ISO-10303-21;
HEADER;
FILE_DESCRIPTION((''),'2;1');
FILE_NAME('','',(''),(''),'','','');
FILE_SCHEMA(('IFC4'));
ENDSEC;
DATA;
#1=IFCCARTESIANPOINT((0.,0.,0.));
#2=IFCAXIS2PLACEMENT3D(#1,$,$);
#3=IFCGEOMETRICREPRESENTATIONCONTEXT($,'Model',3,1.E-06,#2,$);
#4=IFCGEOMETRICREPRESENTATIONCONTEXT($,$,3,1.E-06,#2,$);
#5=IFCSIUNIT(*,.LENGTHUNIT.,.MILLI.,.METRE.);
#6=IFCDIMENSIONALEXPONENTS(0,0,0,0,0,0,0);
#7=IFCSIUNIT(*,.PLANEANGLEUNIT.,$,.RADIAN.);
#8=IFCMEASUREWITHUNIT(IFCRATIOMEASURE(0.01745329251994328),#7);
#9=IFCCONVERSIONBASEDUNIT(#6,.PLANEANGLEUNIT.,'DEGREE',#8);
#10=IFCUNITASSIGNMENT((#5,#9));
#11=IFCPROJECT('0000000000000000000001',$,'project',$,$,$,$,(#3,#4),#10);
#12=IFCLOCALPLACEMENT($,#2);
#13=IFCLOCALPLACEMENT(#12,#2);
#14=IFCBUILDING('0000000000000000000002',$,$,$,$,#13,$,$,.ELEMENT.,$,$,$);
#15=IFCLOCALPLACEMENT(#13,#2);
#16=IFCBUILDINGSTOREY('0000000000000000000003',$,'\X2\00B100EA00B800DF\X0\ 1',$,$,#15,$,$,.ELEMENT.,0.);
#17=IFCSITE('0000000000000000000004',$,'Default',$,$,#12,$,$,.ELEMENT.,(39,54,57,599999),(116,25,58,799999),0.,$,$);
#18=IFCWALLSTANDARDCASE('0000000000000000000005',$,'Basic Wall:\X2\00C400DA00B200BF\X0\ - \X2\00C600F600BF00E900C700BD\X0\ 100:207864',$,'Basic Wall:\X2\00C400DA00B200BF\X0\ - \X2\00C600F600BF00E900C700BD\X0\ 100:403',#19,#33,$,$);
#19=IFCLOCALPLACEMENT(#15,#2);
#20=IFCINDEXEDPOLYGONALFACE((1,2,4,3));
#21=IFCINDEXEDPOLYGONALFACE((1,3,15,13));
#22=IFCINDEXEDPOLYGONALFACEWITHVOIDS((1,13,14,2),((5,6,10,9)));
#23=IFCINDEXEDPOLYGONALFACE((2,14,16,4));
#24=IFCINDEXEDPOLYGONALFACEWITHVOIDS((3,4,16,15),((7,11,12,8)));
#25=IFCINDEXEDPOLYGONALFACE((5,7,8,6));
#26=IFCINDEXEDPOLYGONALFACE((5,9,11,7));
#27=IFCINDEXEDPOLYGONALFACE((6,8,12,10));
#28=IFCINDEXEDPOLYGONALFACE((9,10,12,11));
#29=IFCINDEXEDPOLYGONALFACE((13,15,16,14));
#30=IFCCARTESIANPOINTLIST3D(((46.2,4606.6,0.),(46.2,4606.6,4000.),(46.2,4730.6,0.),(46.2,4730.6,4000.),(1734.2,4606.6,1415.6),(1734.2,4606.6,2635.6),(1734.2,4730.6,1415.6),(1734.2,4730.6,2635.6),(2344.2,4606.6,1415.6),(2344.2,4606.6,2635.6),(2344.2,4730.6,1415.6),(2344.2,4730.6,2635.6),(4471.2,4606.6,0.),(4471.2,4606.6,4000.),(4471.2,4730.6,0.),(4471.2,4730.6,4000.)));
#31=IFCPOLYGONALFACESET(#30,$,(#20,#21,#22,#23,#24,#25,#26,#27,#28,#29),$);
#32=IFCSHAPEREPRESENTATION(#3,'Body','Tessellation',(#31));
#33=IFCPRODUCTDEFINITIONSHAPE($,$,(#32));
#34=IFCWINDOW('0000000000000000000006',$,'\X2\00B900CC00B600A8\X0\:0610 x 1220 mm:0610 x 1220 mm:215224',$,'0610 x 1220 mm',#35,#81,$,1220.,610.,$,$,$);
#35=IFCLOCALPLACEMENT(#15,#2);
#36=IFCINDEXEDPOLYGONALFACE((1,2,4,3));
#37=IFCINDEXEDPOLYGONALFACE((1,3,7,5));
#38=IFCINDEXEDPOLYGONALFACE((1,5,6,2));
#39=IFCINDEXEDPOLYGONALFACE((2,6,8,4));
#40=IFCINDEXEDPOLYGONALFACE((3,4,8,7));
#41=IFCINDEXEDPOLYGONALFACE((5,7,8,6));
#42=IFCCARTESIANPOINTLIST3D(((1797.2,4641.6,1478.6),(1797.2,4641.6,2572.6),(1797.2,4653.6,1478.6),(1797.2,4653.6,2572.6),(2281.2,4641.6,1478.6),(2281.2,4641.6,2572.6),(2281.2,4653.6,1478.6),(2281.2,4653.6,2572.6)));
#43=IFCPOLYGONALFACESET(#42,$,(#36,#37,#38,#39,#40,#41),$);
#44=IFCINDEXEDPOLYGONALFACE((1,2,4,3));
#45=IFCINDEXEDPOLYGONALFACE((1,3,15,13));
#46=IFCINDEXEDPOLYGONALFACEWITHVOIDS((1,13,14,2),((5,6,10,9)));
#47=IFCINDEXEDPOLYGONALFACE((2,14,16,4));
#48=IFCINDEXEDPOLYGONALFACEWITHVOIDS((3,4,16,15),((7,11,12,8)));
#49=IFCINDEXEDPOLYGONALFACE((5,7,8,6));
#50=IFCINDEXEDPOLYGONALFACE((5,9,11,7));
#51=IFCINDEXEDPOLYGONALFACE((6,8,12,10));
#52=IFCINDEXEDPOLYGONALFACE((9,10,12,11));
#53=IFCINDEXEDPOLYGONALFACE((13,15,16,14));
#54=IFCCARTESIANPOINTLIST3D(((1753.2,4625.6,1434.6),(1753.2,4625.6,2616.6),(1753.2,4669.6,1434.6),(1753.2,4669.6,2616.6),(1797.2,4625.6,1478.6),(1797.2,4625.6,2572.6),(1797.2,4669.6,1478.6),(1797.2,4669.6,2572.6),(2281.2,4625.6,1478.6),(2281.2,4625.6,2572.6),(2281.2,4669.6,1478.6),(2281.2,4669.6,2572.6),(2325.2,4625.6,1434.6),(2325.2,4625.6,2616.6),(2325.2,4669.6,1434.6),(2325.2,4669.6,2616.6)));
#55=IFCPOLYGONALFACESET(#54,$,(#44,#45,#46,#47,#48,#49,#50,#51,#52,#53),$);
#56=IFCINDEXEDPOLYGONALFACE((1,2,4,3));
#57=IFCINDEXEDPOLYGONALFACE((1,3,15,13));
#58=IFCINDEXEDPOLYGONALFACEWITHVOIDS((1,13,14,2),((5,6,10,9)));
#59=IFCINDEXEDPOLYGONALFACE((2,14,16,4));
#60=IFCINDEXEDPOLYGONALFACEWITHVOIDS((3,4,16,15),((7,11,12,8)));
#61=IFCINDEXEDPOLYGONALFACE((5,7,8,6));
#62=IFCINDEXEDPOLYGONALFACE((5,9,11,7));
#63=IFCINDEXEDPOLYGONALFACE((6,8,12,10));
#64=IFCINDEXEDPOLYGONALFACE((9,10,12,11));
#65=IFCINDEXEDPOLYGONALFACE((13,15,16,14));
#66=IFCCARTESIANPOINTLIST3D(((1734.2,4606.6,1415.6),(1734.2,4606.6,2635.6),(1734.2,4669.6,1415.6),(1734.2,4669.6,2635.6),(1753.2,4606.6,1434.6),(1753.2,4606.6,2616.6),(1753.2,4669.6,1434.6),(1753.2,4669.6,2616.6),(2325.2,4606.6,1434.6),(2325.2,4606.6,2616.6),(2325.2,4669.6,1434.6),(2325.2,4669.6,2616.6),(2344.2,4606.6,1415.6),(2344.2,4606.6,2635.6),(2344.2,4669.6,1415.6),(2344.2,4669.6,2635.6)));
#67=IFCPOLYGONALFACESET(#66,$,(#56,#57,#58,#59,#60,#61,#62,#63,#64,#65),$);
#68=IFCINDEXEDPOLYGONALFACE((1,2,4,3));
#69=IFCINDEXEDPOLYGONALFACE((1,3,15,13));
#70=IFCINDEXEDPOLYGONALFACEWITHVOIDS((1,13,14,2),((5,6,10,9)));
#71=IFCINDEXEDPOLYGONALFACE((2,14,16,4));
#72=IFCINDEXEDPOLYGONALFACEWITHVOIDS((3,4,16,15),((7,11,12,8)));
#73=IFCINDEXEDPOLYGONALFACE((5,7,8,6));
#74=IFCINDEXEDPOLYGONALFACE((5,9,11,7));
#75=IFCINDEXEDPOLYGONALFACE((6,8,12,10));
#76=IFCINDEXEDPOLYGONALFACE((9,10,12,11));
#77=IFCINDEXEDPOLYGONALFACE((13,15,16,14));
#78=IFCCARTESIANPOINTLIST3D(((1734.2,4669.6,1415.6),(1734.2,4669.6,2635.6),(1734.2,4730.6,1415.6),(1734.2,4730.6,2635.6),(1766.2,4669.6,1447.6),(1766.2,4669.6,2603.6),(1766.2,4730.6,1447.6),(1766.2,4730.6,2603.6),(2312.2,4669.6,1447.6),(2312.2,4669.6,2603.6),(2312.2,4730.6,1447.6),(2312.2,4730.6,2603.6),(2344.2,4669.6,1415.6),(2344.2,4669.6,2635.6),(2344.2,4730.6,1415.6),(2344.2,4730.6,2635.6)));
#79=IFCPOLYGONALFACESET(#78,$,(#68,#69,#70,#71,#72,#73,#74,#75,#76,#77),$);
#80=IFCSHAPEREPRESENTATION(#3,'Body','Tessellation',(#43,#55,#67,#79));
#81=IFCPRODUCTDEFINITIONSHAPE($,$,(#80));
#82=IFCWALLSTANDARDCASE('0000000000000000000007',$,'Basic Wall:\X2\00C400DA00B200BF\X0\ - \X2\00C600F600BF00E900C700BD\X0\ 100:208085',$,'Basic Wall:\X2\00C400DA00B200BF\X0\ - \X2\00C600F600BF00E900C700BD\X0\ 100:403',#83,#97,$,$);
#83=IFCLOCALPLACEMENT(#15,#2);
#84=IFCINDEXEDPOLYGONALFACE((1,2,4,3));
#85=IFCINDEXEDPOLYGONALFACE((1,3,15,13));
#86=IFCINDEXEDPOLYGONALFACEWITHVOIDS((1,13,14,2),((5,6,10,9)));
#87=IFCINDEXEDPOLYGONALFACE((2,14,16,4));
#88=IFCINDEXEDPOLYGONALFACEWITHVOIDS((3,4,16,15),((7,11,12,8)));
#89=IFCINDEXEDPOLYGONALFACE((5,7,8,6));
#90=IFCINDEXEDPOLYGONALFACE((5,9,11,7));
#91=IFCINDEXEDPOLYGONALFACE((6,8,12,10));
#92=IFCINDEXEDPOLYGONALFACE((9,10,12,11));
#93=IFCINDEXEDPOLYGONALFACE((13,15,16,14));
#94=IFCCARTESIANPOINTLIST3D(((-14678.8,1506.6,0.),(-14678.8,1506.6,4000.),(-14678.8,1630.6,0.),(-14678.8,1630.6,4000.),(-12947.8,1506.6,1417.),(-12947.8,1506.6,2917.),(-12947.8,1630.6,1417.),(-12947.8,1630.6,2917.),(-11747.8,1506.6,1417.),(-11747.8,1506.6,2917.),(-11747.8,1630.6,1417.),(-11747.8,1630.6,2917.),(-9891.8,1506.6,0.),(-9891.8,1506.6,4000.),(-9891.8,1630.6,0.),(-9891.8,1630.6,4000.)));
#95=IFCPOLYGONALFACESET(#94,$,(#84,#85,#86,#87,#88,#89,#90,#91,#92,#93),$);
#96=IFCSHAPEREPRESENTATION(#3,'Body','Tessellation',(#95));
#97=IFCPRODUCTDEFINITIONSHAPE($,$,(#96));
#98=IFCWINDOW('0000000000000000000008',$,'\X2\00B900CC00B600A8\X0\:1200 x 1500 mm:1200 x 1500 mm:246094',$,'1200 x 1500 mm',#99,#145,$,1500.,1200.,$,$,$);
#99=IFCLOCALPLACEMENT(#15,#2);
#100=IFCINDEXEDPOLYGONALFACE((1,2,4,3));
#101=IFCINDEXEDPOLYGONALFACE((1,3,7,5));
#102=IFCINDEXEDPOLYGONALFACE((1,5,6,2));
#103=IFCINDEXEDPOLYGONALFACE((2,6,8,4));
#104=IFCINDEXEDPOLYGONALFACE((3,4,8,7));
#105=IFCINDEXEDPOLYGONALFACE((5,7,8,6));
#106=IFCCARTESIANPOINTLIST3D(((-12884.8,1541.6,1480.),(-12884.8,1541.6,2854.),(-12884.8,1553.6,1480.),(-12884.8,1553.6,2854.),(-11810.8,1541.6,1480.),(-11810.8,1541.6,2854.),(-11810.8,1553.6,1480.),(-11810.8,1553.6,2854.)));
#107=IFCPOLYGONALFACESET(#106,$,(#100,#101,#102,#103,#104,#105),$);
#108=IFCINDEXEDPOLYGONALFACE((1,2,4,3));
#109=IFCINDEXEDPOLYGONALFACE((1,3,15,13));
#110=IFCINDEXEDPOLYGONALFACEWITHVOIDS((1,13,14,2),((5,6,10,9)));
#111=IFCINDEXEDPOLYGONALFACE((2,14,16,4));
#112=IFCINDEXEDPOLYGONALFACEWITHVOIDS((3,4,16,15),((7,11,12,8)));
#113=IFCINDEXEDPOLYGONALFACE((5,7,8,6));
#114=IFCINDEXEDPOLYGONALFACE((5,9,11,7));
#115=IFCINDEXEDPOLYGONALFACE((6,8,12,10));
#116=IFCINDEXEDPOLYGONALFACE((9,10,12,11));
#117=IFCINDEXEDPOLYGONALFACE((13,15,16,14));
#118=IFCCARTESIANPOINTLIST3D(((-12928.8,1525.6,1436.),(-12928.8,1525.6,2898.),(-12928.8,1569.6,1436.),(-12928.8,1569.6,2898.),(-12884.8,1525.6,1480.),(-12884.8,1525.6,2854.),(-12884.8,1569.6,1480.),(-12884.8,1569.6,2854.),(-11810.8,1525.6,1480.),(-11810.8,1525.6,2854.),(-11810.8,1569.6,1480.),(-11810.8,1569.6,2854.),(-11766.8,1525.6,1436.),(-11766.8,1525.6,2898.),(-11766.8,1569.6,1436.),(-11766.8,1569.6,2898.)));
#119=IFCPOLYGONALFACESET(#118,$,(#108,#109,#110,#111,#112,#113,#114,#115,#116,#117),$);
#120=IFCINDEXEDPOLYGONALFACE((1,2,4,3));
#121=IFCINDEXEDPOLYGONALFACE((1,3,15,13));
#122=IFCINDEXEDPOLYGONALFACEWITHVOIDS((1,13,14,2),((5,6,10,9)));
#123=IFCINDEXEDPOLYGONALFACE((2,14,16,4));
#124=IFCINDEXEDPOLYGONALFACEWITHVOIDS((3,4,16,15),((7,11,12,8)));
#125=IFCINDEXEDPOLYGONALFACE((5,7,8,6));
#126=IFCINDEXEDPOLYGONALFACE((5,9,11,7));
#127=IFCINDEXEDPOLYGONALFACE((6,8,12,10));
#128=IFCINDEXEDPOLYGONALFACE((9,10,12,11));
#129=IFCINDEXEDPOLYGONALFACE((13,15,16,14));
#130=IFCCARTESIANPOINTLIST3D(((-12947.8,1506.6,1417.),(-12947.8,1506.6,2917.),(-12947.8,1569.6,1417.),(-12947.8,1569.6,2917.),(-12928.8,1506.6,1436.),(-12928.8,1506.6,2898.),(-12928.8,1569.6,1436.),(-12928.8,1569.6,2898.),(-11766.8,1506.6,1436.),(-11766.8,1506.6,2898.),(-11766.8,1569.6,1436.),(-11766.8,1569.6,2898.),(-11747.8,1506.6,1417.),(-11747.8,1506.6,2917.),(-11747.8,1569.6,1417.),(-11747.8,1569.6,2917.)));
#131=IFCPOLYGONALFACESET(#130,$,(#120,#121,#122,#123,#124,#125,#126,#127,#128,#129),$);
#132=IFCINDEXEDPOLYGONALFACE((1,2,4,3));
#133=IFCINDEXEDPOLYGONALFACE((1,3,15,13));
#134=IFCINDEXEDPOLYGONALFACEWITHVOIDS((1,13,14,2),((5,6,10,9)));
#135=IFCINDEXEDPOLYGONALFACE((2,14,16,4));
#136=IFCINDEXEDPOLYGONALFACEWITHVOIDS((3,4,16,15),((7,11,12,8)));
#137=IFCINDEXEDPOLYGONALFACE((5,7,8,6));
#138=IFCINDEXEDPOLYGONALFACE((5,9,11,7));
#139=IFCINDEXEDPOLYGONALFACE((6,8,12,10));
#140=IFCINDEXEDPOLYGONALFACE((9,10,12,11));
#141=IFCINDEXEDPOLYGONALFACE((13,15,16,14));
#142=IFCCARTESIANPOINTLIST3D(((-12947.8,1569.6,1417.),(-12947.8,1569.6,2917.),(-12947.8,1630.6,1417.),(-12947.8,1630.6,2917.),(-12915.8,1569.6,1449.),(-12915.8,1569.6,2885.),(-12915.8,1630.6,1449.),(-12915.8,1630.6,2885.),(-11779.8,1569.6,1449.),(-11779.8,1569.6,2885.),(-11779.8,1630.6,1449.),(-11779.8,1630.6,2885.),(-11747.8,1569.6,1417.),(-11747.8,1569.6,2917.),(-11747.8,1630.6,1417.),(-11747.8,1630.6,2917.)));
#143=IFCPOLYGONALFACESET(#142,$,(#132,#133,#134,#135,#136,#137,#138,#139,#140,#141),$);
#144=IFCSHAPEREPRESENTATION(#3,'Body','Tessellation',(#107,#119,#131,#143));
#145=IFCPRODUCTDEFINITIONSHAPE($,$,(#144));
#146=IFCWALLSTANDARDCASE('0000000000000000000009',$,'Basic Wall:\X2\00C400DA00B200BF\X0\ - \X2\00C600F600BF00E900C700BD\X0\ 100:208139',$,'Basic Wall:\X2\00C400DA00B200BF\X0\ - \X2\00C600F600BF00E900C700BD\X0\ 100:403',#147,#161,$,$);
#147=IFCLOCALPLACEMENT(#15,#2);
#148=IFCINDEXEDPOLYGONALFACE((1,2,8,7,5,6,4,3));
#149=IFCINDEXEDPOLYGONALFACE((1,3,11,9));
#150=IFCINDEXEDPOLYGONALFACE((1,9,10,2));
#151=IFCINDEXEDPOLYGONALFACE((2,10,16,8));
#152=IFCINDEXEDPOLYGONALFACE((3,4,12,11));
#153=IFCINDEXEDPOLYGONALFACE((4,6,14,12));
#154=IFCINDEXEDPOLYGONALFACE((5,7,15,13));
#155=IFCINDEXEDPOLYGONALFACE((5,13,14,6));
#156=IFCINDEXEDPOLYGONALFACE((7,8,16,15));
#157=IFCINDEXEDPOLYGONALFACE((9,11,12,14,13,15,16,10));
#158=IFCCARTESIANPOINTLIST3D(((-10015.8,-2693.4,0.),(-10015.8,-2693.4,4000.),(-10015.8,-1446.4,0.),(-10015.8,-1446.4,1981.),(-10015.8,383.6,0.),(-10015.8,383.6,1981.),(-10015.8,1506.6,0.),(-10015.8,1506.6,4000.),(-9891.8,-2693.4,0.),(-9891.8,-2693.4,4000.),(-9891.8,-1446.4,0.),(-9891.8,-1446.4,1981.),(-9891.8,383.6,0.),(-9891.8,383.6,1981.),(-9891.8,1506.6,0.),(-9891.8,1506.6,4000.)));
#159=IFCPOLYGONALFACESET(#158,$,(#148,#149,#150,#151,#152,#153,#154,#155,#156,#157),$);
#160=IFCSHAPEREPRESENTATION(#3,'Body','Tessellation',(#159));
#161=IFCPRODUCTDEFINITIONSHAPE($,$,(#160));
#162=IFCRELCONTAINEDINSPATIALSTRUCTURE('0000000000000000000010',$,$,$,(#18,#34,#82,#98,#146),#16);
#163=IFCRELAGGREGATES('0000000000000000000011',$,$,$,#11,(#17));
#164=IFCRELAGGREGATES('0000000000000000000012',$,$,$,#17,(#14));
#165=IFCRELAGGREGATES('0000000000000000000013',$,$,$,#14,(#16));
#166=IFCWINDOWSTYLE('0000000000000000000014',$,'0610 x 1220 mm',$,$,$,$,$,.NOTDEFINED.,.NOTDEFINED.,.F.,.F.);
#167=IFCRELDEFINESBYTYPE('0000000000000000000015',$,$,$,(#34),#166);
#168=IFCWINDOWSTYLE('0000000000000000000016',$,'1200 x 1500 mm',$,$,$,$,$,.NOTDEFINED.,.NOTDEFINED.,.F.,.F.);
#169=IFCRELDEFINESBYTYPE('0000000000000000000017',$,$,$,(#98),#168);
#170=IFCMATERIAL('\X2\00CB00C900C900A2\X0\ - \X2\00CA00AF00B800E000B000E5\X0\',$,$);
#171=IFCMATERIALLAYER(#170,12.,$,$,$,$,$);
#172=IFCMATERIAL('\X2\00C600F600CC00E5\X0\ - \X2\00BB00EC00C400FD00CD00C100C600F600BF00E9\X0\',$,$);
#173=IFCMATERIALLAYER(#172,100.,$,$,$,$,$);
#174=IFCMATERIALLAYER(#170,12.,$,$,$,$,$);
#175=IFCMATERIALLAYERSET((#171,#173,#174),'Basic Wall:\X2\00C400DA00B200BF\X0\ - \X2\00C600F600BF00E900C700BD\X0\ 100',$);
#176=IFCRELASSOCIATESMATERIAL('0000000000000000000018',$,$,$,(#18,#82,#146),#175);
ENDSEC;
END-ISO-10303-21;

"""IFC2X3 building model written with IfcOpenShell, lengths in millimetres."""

from ifc_helpers import new_model, entity, si_unit, converted_unit, frame, frame_2d, origin, origin_2d_with_axis, place, context, project, spatial, polyline, rectangle, outline, extrude, source, transform, mapped, material, layer, layer_set, layer_usage, type_object, type_shapes, element, fill, save


model = new_model("IFC2X3")

# Units and contexts
model_context = context("Model", 3, precision=1e-06, world=origin())
context_of_model = context(None, 3, precision=1e-06, world=origin())
ifc_project = project(units=[si_unit("LENGTHUNIT", "METRE", prefix="MILLI"), converted_unit("PLANEANGLEUNIT", "DEGREE", entity("IfcRatioMeasure", 0.01745329251994328), si_unit("PLANEANGLEUNIT", "RADIAN"), dimensions=[0, 0, 0, 0, 0, 0, 0])], contexts=[model_context, context_of_model])

# Site, building, storey
site_placement = place(None, origin())
site = spatial("IfcSite", under=ifc_project, at=site_placement, Name="Default", CompositionType="ELEMENT", RefLatitude=(39, 54, 57, 599999), RefLongitude=(116, 25, 58, 799999), RefElevation=0.0)
building_placement = place(site_placement, origin())
building = spatial("IfcBuilding", under=site, at=building_placement, CompositionType="ELEMENT")
storey_placement = place(building_placement, origin())
storey = spatial("IfcBuildingStorey", under=building, at=storey_placement, Name="±ê¸ß 1", CompositionType="ELEMENT", Elevation=0.0)

# Shared definitions
ifc_material_1 = material(Name="ËÉÉ¢ - Ê¯¸à°å")

# Shared definitions
ifc_layer_1 = layer(ifc_material_1, 12.0)
ifc_material_2 = material(Name="ÆöÌå - »ìÄýÍÁÆö¿é")
ifc_layer_2 = layer(ifc_material_2, 100.0)
ifc_layer_3 = layer(ifc_material_1, 12.0)
ifc_layer_set_1 = layer_set([ifc_layer_1, ifc_layer_2, ifc_layer_3], Name="Basic Wall:ÄÚ²¿ - Æö¿éÇ½ 100")

# Walls, openings, windows
ifc_layer_usage_1 = layer_usage(ifc_layer_set_1, "AXIS2", "NEGATIVE", 62.0)
wall_1_placement = place(storey_placement, frame((46.2, 4668.6, 0.0)))
wall_1 = element("IfcWallStandardCase", 1, at=wall_1_placement, inside=storey, material=ifc_layer_usage_1, Name="Basic Wall:ÄÚ²¿ - Æö¿éÇ½ 100:207864", ObjectType="Basic Wall:ÄÚ²¿ - Æö¿éÇ½ 100:403", context=model_context, shape_type="SweptSolid", body=[
    extrude(rectangle(XDim=4425.0, YDim=124.0, at=frame_2d((2212.5, 0.0), x_axis=(-1.0, 0.0))), origin(), (0.0, 0.0, 1.0), 4000.0),
])
opening_1_placement = place(wall_1_placement, frame((1688.0, -62.0, 1415.6)))
opening_1 = element("IfcOpeningElement", 2, at=opening_1_placement, cuts=wall_1, ObjectType="Opening", context=model_context, shape_type="SweptSolid", body=[
    extrude(rectangle(XDim=1220.0, YDim=610.0, at=frame_2d((610.0, 305.0), x_axis=(1.0, 0.0))), frame((0.0, 0.0, 0.0), z_axis=(0.0, 1.0, 0.0), x_axis=(0.0, 0.0, 1.0)), (0.0, 0.0, 1.0), 124.0),
])
window_style_1 = type_object("IfcWindowStyle", Name="0610 x 1220 mm", ConstructionType="NOTDEFINED", OperationType="NOTDEFINED", ParameterTakesPrecedence=False, Sizeable=False)
shared_shape_1 = source(origin(), model_context, "Body", "SweptSolid", [
    extrude(rectangle(XDim=12.0, YDim=484.0, at=origin_2d_with_axis()), frame((305.0, 83.0, 63.0), z_axis=(0.0, 0.0, 1.0), x_axis=(0.0, -1.0, 0.0)), (0.0, 0.0, 1.0), 1094.0),
    extrude(outline(polyline([(-286.0, -591.0), (286.0, -591.0), (286.0, 591.0), (-286.0, 591.0), (-286.0, -591.0)]), holes=[polyline([(-242.0, -547.0), (-242.0, 547.0), (242.0, 547.0), (242.0, -547.0), (-242.0, -547.0)])]), frame((305.0, 61.0, 610.0), z_axis=(0.0, 1.0, 0.0), x_axis=(1.0, 0.0, 0.0)), (0.0, 0.0, 1.0), 44.0),
    extrude(outline(polyline([(-305.0, -610.0), (305.0, -610.0), (305.0, 610.0), (-305.0, 610.0), (-305.0, -610.0)]), holes=[polyline([(-286.0, -591.0), (-286.0, 591.0), (286.0, 591.0), (286.0, -591.0), (-286.0, -591.0)])]), frame((305.0, 61.0, 610.0), z_axis=(0.0, 1.0, 0.0), x_axis=(1.0, 0.0, 0.0)), (0.0, 0.0, 1.0), 63.0),
    extrude(outline(polyline([(-305.0, -610.0), (305.0, -610.0), (305.0, 610.0), (-305.0, 610.0), (-305.0, -610.0)]), holes=[polyline([(-273.0, -578.0), (-273.0, 578.0), (273.0, 578.0), (273.0, -578.0), (-273.0, -578.0)])]), frame((305.0, 0.0, 610.0), z_axis=(0.0, 1.0, 0.0), x_axis=(1.0, 0.0, 0.0)), (0.0, 0.0, 1.0), 61.0),
])
type_shapes(window_style_1, [shared_shape_1])
window_1_placement = place(opening_1_placement, frame((610.0, 124.0, 0.0), z_axis=(0.0, 0.0, 1.0), x_axis=(-1.0, 0.0, 0.0)))
window_1 = element("IfcWindow", 3, at=window_1_placement, inside=storey, type_object=window_style_1, Name="¹Ì¶¨:0610 x 1220 mm:0610 x 1220 mm:215224", ObjectType="0610 x 1220 mm", OverallHeight=1220.0, OverallWidth=610.0, context=model_context, shape_type="MappedRepresentation", body=[
    mapped(shared_shape_1, transform((0.0, 0.0, 0.0), scale=1.0)),
])
fill(opening_1, window_1)
ifc_layer_usage_2 = layer_usage(ifc_layer_set_1, "AXIS2", "NEGATIVE", 62.0)
wall_2_placement = place(storey_placement, frame((-14678.8, 1568.6, 0.0)))
wall_2 = element("IfcWallStandardCase", 4, at=wall_2_placement, inside=storey, material=ifc_layer_usage_2, Name="Basic Wall:ÄÚ²¿ - Æö¿éÇ½ 100:208085", ObjectType="Basic Wall:ÄÚ²¿ - Æö¿éÇ½ 100:403", context=model_context, shape_type="SweptSolid", body=[
    extrude(rectangle(XDim=4787.0, YDim=124.0, at=frame_2d((2393.5, 0.0), x_axis=(-1.0, 0.0))), origin(), (0.0, 0.0, 1.0), 4000.0),
])
opening_2_placement = place(wall_2_placement, frame((1731.0, -62.0, 1417.0)))
opening_2 = element("IfcOpeningElement", 5, at=opening_2_placement, cuts=wall_2, ObjectType="Opening", context=model_context, shape_type="SweptSolid", body=[
    extrude(rectangle(XDim=1500.0, YDim=1200.0, at=frame_2d((750.0, 600.0), x_axis=(1.0, 0.0))), frame((0.0, 0.0, 0.0), z_axis=(0.0, 1.0, 0.0), x_axis=(0.0, 0.0, 1.0)), (0.0, 0.0, 1.0), 124.0),
])
window_style_2 = type_object("IfcWindowStyle", Name="1200 x 1500 mm", ConstructionType="NOTDEFINED", OperationType="NOTDEFINED", ParameterTakesPrecedence=False, Sizeable=False)
shared_shape_2 = source(origin(), model_context, "Body", "SweptSolid", [
    extrude(rectangle(XDim=12.0, YDim=1074.0, at=origin_2d_with_axis()), frame((600.0, 83.0, 63.0), z_axis=(0.0, 0.0, 1.0), x_axis=(0.0, -1.0, 0.0)), (0.0, 0.0, 1.0), 1374.0),
    extrude(outline(polyline([(-581.0, -731.0), (581.0, -731.0), (581.0, 731.0), (-581.0, 731.0), (-581.0, -731.0)]), holes=[polyline([(-537.0, -687.0), (-537.0, 687.0), (537.0, 687.0), (537.0, -687.0), (-537.0, -687.0)])]), frame((600.0, 61.0, 750.0), z_axis=(0.0, 1.0, 0.0), x_axis=(1.0, 0.0, 0.0)), (0.0, 0.0, 1.0), 44.0),
    extrude(outline(polyline([(-600.0, -750.0), (600.0, -750.0), (600.0, 750.0), (-600.0, 750.0), (-600.0, -750.0)]), holes=[polyline([(-581.0, -731.0), (-581.0, 731.0), (581.0, 731.0), (581.0, -731.0), (-581.0, -731.0)])]), frame((600.0, 61.0, 750.0), z_axis=(0.0, 1.0, 0.0), x_axis=(1.0, 0.0, 0.0)), (0.0, 0.0, 1.0), 63.0),
    extrude(outline(polyline([(-600.0, -750.0), (600.0, -750.0), (600.0, 750.0), (-600.0, 750.0), (-600.0, -750.0)]), holes=[polyline([(-568.0, -718.0), (-568.0, 718.0), (568.0, 718.0), (568.0, -718.0), (-568.0, -718.0)])]), frame((600.0, 0.0, 750.0), z_axis=(0.0, 1.0, 0.0), x_axis=(1.0, 0.0, 0.0)), (0.0, 0.0, 1.0), 61.0),
])
type_shapes(window_style_2, [shared_shape_2])
window_2_placement = place(opening_2_placement, frame((1200.0, 124.0, 0.0), z_axis=(0.0, 0.0, 1.0), x_axis=(-1.0, 0.0, 0.0)))
window_2 = element("IfcWindow", 6, at=window_2_placement, inside=storey, type_object=window_style_2, Name="¹Ì¶¨:1200 x 1500 mm:1200 x 1500 mm:246094", ObjectType="1200 x 1500 mm", OverallHeight=1500.0, OverallWidth=1200.0, context=model_context, shape_type="MappedRepresentation", body=[
    mapped(shared_shape_2, transform((0.0, 0.0, 0.0), scale=1.0)),
])
fill(opening_2, window_2)

# Wall, opening
ifc_layer_usage_3 = layer_usage(ifc_layer_set_1, "AXIS2", "NEGATIVE", 62.0)
wall_3_placement = place(storey_placement, frame((-9953.8, 1506.6, 0.0), z_axis=(0.0, 0.0, 1.0), x_axis=(0.0, -1.0, 0.0)))
wall_3 = element("IfcWallStandardCase", 7, at=wall_3_placement, inside=storey, material=ifc_layer_usage_3, Name="Basic Wall:ÄÚ²¿ - Æö¿éÇ½ 100:208139", ObjectType="Basic Wall:ÄÚ²¿ - Æö¿éÇ½ 100:403", context=model_context, shape_type="SweptSolid", body=[
    extrude(rectangle(XDim=4200.0, YDim=124.0, at=frame_2d((2100.0, 0.0), x_axis=(-1.0, 0.0))), origin(), (0.0, 0.0, 1.0), 4000.0),
])
opening_3_placement = place(wall_3_placement, frame((2953.0, 62.0, 0.0)))
element("IfcOpeningElement", 8, at=opening_3_placement, cuts=wall_3, ObjectType="Opening", context=model_context, shape_type="SweptSolid", body=[
    extrude(rectangle(XDim=1981.0, YDim=1830.0, at=frame_2d((990.5, 915.0), x_axis=(1.0, 0.0))), frame((0.0, 0.0, 0.0), z_axis=(0.0, -1.0, 0.0), x_axis=(0.0, 0.0, 1.0)), (0.0, 0.0, 1.0), 124.0),
])

save(model, "model.ifc")
